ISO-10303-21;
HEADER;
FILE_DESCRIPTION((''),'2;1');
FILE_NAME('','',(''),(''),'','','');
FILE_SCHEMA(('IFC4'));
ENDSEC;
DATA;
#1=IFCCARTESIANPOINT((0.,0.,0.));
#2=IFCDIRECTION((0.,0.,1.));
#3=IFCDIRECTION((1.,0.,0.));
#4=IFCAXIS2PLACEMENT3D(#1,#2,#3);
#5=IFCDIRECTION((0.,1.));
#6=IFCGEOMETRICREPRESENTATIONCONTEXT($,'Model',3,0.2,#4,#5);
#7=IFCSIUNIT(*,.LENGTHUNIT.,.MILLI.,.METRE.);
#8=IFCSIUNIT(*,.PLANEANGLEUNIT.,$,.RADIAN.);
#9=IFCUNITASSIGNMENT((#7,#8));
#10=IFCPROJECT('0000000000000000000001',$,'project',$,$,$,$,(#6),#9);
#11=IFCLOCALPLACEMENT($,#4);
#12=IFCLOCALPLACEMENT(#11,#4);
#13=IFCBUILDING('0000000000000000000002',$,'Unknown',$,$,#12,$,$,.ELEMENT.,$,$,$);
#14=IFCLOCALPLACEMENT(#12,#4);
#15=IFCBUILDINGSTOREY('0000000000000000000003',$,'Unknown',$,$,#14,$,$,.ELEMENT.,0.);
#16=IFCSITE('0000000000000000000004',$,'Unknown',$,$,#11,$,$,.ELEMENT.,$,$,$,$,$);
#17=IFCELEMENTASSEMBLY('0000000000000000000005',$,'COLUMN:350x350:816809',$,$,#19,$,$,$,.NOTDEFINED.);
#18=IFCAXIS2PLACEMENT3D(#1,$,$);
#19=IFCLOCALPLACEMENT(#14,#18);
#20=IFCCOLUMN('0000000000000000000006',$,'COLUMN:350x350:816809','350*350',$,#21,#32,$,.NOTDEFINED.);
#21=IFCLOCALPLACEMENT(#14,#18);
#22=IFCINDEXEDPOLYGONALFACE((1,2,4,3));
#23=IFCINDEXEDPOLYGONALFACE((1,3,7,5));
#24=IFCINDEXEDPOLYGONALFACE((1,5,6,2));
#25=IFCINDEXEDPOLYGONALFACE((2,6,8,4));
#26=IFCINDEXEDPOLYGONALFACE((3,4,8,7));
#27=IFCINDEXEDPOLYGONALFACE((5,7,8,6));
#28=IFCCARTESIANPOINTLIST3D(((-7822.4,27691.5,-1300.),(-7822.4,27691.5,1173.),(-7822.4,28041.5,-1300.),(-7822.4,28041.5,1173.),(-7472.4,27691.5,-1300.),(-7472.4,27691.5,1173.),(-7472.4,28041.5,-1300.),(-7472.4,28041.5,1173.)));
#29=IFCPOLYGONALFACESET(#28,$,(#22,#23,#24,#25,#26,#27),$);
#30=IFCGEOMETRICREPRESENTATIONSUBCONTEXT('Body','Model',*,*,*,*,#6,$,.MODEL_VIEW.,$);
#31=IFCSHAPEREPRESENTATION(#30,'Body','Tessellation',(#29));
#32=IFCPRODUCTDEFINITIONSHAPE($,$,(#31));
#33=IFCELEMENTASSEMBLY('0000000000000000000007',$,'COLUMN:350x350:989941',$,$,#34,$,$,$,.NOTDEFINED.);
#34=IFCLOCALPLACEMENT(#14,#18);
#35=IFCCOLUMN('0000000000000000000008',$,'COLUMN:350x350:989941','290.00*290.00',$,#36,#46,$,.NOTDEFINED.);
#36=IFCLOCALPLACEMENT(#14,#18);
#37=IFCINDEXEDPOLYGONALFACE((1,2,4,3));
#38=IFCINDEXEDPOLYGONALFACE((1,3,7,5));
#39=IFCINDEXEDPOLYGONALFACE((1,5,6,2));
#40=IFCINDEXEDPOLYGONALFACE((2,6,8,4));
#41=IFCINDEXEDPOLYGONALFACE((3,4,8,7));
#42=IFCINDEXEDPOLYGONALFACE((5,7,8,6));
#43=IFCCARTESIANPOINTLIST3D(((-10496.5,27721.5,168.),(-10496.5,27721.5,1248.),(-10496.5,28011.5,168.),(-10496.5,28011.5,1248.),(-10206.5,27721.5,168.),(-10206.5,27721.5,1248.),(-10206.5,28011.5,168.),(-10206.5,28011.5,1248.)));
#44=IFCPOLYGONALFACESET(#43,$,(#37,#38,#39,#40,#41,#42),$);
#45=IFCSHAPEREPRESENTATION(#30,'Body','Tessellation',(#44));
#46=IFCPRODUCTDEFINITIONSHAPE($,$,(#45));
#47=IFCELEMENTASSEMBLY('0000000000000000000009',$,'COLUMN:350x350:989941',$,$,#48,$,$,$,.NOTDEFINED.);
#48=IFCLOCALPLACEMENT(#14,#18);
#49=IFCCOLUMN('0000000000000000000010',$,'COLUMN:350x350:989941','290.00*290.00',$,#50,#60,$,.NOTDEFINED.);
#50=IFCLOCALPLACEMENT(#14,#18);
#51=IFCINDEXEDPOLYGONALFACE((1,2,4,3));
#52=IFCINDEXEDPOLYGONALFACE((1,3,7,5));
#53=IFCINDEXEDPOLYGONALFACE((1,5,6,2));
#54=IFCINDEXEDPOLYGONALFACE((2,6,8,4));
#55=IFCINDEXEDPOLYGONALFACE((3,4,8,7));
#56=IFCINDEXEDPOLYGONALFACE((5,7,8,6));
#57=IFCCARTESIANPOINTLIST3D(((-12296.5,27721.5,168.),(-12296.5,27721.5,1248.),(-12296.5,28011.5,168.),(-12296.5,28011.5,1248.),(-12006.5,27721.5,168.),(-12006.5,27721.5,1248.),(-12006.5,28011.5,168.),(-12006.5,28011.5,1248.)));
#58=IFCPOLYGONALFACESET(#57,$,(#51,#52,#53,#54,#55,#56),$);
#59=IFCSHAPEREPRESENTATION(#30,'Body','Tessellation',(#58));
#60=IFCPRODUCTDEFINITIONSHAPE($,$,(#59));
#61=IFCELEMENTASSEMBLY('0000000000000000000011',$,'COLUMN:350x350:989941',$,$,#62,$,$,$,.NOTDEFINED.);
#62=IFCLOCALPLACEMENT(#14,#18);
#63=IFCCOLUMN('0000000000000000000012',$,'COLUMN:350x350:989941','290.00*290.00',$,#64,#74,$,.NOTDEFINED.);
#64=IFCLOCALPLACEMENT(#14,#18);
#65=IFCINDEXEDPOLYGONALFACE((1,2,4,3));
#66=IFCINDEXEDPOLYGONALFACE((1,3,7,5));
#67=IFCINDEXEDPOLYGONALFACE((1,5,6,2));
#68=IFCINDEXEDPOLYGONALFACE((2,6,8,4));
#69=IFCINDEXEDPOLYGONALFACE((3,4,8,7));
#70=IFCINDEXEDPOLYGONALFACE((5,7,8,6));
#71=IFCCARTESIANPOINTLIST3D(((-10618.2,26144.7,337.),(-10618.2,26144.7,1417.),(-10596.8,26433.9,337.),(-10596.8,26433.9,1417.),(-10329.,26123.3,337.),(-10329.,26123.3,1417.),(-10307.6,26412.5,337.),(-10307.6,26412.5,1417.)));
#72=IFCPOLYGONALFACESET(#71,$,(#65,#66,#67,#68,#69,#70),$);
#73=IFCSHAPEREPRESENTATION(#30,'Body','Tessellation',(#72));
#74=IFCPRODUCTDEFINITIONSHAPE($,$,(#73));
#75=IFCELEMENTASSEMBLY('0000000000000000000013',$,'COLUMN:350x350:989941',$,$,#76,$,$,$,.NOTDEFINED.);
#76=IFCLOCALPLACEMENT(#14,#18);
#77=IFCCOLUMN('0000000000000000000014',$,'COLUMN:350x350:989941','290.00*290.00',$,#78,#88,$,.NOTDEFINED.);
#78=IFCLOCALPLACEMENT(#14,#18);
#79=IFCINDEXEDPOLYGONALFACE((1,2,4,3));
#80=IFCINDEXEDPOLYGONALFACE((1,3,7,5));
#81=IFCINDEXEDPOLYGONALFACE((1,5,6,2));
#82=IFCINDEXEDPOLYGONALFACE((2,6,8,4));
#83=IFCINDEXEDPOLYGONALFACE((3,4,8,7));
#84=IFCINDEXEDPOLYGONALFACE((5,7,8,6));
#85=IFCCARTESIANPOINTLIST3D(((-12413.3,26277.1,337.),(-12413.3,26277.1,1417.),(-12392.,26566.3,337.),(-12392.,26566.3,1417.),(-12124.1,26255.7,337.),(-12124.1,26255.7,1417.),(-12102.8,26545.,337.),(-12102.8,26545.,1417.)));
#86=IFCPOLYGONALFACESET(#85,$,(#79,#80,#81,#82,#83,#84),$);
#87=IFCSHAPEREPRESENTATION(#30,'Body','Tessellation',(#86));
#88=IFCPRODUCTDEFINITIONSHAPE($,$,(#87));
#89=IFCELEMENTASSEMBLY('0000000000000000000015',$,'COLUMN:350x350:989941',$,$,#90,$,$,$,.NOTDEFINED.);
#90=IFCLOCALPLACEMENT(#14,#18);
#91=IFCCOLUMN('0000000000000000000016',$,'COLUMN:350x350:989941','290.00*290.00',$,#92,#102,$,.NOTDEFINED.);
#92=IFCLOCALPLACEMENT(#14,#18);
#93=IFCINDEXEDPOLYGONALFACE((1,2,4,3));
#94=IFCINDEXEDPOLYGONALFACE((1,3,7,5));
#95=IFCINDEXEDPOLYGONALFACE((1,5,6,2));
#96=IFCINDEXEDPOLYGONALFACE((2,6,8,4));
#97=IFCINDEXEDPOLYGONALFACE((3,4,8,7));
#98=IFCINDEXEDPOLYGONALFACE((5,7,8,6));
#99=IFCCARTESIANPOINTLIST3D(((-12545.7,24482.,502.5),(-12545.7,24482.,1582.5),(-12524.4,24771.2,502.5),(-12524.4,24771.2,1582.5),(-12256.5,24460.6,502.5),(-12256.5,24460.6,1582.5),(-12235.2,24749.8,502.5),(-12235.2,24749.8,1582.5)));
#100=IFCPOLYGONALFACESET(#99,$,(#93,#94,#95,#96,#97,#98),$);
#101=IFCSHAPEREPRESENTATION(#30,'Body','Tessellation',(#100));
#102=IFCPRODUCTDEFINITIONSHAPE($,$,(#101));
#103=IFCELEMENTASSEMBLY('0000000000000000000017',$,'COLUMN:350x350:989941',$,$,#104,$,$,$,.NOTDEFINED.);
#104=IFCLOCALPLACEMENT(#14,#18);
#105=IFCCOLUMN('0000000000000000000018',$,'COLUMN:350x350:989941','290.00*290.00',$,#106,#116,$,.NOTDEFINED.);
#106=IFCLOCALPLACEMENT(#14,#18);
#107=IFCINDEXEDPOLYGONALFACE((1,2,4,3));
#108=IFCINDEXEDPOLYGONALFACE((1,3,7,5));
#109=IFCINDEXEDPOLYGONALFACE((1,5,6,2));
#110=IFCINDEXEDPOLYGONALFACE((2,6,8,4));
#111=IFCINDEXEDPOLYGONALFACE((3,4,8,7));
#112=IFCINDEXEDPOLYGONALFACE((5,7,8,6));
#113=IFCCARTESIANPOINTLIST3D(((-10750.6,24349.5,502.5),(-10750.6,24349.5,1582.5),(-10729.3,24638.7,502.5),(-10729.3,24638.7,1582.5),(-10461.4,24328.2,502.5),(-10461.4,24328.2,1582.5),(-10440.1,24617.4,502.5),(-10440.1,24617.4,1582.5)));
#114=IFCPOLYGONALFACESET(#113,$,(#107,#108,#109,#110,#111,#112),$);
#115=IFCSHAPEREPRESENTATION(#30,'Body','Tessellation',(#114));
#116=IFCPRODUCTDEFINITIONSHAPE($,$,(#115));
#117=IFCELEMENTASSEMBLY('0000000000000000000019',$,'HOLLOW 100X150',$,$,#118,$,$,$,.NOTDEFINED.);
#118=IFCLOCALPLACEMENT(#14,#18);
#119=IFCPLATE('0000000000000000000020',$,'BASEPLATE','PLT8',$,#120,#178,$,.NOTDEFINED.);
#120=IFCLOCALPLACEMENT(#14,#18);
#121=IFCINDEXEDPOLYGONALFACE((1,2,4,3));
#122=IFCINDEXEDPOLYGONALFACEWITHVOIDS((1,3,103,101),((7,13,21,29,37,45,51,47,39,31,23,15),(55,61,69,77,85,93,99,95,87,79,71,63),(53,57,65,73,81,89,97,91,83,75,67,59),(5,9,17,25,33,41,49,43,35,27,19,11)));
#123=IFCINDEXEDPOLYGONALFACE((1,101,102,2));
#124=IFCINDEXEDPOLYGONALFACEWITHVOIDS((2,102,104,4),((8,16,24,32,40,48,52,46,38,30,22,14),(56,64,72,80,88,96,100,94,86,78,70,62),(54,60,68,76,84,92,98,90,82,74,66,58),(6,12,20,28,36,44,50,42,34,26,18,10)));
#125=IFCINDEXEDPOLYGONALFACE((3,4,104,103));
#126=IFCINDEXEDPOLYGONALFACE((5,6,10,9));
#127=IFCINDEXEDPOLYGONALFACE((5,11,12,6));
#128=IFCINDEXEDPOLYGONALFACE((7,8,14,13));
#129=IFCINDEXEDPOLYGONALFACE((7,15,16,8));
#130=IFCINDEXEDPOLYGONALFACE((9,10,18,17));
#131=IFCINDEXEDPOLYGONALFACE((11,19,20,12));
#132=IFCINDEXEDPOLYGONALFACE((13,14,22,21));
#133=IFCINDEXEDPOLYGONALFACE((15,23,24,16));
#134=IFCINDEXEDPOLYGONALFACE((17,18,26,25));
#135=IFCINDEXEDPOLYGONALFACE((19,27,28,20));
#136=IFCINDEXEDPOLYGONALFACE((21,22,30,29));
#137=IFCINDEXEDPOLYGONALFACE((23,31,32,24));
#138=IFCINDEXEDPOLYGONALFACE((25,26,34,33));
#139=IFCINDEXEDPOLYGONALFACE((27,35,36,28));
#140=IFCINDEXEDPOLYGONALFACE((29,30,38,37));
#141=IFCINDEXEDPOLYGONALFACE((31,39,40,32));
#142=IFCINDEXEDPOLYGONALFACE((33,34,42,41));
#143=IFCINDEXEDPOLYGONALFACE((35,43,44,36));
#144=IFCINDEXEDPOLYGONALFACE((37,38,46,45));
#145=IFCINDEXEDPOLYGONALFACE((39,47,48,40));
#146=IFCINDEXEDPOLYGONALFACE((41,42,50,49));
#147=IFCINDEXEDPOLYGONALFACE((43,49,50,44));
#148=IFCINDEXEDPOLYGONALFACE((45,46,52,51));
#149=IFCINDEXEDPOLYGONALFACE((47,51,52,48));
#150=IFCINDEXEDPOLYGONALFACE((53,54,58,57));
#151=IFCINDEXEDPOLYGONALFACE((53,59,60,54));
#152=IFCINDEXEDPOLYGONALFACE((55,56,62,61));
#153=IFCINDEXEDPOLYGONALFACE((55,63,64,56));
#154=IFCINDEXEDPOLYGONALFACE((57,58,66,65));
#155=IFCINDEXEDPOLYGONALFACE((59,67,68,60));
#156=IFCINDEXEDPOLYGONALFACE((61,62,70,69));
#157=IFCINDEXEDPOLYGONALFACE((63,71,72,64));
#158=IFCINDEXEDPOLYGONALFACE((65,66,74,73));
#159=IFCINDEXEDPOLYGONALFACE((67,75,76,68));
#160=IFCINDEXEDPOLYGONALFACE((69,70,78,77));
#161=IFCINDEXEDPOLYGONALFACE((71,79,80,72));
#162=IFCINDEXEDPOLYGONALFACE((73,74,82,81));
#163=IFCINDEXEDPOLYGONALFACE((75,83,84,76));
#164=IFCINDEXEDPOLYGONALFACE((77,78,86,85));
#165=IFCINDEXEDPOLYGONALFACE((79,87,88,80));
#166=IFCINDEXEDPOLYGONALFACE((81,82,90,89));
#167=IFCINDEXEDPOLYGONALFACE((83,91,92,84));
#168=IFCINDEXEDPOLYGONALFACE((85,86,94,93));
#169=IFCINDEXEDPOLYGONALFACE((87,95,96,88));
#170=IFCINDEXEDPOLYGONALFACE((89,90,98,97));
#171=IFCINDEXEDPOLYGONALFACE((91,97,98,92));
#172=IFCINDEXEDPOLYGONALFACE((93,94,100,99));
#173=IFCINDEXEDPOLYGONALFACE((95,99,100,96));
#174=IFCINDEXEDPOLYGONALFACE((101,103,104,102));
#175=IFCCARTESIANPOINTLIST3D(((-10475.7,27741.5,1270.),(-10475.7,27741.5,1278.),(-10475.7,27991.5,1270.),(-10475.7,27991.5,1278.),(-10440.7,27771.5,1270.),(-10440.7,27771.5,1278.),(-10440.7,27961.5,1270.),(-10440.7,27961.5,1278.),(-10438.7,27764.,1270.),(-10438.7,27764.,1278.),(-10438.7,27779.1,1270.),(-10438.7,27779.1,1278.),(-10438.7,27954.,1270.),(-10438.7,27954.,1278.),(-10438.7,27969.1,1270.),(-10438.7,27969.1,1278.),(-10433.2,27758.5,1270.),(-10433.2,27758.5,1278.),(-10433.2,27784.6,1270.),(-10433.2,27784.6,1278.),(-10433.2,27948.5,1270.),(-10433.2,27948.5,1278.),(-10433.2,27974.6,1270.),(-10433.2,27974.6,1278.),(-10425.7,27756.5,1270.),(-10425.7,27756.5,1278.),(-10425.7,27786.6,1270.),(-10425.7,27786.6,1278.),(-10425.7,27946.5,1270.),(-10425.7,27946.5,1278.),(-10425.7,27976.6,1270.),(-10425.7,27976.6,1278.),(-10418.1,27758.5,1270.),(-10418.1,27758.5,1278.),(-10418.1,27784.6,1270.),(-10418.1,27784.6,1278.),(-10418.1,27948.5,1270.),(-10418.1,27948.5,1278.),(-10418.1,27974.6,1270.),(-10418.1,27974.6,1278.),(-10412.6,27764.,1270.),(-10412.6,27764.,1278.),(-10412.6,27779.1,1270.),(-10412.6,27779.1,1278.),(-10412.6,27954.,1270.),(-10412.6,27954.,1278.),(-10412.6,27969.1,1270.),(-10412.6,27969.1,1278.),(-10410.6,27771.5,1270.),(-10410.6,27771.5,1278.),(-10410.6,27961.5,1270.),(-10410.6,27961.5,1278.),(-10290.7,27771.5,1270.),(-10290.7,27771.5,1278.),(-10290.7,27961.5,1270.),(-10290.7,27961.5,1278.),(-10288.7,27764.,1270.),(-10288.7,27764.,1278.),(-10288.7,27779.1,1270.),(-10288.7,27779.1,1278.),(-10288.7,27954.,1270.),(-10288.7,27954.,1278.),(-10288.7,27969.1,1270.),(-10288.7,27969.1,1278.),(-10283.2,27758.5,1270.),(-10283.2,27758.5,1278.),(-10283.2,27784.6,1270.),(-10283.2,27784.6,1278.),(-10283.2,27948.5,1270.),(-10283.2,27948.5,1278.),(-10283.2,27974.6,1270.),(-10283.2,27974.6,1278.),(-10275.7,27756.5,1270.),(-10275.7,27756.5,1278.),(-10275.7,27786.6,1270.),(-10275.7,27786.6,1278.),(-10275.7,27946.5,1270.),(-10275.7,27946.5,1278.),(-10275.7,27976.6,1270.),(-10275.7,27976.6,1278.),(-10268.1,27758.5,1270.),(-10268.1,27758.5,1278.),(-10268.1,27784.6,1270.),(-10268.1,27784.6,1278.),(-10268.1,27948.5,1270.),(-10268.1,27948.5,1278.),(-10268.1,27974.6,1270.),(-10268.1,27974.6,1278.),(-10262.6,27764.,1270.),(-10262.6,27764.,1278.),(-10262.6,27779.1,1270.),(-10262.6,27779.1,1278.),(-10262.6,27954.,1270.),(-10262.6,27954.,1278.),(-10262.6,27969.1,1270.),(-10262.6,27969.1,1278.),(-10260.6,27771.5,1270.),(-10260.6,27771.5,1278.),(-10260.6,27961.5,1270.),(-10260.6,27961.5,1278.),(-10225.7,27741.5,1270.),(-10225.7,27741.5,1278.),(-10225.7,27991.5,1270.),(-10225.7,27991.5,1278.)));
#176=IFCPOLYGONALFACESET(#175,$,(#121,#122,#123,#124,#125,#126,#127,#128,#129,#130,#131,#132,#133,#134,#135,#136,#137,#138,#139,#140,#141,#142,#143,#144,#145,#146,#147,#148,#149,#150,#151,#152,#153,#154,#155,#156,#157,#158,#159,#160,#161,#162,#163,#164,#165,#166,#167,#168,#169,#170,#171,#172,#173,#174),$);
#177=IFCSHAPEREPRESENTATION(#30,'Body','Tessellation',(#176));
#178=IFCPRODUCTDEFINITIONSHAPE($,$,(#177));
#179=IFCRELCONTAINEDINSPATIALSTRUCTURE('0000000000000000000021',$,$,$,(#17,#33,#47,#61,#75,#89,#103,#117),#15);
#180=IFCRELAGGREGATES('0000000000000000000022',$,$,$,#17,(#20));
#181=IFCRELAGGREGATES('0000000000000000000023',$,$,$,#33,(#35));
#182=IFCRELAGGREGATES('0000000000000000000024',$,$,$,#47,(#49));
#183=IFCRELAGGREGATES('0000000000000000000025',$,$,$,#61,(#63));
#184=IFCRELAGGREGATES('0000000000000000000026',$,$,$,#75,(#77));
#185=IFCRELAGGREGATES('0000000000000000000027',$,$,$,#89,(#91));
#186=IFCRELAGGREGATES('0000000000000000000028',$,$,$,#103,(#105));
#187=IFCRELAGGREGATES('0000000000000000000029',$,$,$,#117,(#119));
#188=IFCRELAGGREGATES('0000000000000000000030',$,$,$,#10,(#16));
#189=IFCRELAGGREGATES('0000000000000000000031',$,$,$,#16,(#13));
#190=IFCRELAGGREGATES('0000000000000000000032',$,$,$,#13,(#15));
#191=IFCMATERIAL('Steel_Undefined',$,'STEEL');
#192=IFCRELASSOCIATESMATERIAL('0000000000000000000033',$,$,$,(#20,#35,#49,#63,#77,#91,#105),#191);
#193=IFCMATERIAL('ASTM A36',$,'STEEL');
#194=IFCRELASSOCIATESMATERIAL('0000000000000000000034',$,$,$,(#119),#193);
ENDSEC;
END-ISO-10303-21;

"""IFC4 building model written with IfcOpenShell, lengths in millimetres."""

from ifc_helpers import new_model, si_unit, direction, frame, origin_with_axes, place, context, subcontext, project, spatial, line, indexed_curve, outline, extrude, material, element, aggregate, save


model = new_model("IFC4")

# Units and contexts
model_context = context("Model", 3, precision=0.2, world=origin_with_axes(), true_north=direction((0.0, 1.0)))
body_context = subcontext(model_context, "Body", "Model", "MODEL_VIEW")
ifc_project = project(units=[si_unit("LENGTHUNIT", "METRE", prefix="MILLI"), si_unit("PLANEANGLEUNIT", "RADIAN")], contexts=[model_context])

# Site, building, storey
site_placement = place(None, origin_with_axes())
site = spatial("IfcSite", under=ifc_project, at=site_placement, Name="Unknown", CompositionType="ELEMENT")
building_placement = place(site_placement, origin_with_axes())
building = spatial("IfcBuilding", under=site, at=building_placement, Name="Unknown", CompositionType="ELEMENT")
storey_placement = place(building_placement, origin_with_axes())
storey = spatial("IfcBuildingStorey", under=building, at=storey_placement, Name="Unknown", CompositionType="ELEMENT", Elevation=0.0)

# Element assemblies, columns
assembly_1_placement = place(storey_placement, frame((-7647.4, 27866.5, -1300.0), z_axis=(1.0, 0.0, 0.0), x_axis=(0.0, 0.0, 1.0)))
assembly_1 = element("IfcElementAssembly", 1, at=assembly_1_placement, inside=storey, Name="COLUMN:350x350:816809", PredefinedType="NOTDEFINED")
ifc_material_1 = material(Name="Steel_Undefined", Category="STEEL")
column_1_placement = place(assembly_1_placement, origin_with_axes())
column_1 = element("IfcColumn", 2, at=column_1_placement, material=ifc_material_1, Name="COLUMN:350x350:816809", Description="350*350", PredefinedType="NOTDEFINED", context=body_context, shape_type="SolidModel", body=[
    extrude(outline(indexed_curve([(-175.0, -175.0), (175.0, -175.0), (175.0, 175.0), (-175.0, 175.0)], segments=[line(1, 2, 3, 4, 1)])), frame((0.0, 0.0, 0.0), z_axis=(-1.0, 0.0, 0.0), x_axis=(0.0, 0.0, 1.0)), (0.0, 0.0, -1.0), 2473.0),
])
aggregate(assembly_1, [column_1])
assembly_2_placement = place(storey_placement, frame((-10351.5, 27866.5, 168.0), z_axis=(1.0, 0.0, 0.0), x_axis=(0.0, 0.0, 1.0)))
assembly_2 = element("IfcElementAssembly", 3, at=assembly_2_placement, inside=storey, Name="COLUMN:350x350:989941", PredefinedType="NOTDEFINED")
column_2_placement = place(assembly_2_placement, origin_with_axes())
column_2 = element("IfcColumn", 4, at=column_2_placement, material=ifc_material_1, Name="COLUMN:350x350:989941", Description="290.00*290.00", PredefinedType="NOTDEFINED", context=body_context, shape_type="SolidModel", body=[
    extrude(outline(indexed_curve([(-145.0, -145.0), (145.0, -145.0), (145.0, 145.0), (-145.0, 145.0)], segments=[line(1, 2, 3, 4, 1)])), frame((0.0, 0.0, 0.0), z_axis=(-1.0, 0.0, 0.0), x_axis=(0.0, 0.0, 1.0)), (0.0, 0.0, -1.0), 1080.0),
])
aggregate(assembly_2, [column_2])
assembly_3_placement = place(storey_placement, frame((-12151.5, 27866.5, 168.0), z_axis=(1.0, 0.0, 0.0), x_axis=(0.0, 0.0, 1.0)))
assembly_3 = element("IfcElementAssembly", 5, at=assembly_3_placement, inside=storey, Name="COLUMN:350x350:989941", PredefinedType="NOTDEFINED")
column_3_placement = place(assembly_3_placement, origin_with_axes())
column_3 = element("IfcColumn", 6, at=column_3_placement, material=ifc_material_1, Name="COLUMN:350x350:989941", Description="290.00*290.00", PredefinedType="NOTDEFINED", context=body_context, shape_type="SolidModel", body=[
    extrude(outline(indexed_curve([(-145.0, -145.0), (145.0, -145.0), (145.0, 145.0), (-145.0, 145.0)], segments=[line(1, 2, 3, 4, 1)])), frame((0.0, 0.0, 0.0), z_axis=(-1.0, 0.0, 0.0), x_axis=(0.0, 0.0, 1.0)), (0.0, 0.0, -1.0), 1080.0),
])
aggregate(assembly_3, [column_3])
assembly_4_placement = place(storey_placement, frame((-10462.9, 26278.6, 337.0), z_axis=(0.99729, -0.073569, 0.0), x_axis=(0.0, 0.0, 1.0)))
assembly_4 = element("IfcElementAssembly", 7, at=assembly_4_placement, inside=storey, Name="COLUMN:350x350:989941", PredefinedType="NOTDEFINED")
column_4_placement = place(assembly_4_placement, origin_with_axes())
column_4 = element("IfcColumn", 8, at=column_4_placement, material=ifc_material_1, Name="COLUMN:350x350:989941", Description="290.00*290.00", PredefinedType="NOTDEFINED", context=body_context, shape_type="SolidModel", body=[
    extrude(outline(indexed_curve([(-145.0, -145.0), (145.0, -145.0), (145.0, 145.0), (-145.0, 145.0)], segments=[line(1, 2, 3, 4, 1)])), frame((0.0, 0.0, 0.0), z_axis=(-1.0, 0.0, 0.0), x_axis=(0.0, 0.0, 1.0)), (0.0, 0.0, -1.0), 1080.0),
])
aggregate(assembly_4, [column_4])
assembly_5_placement = place(storey_placement, frame((-12258.0, 26411.0, 337.0), z_axis=(0.99729, -0.073569, 0.0), x_axis=(0.0, 0.0, 1.0)))
assembly_5 = element("IfcElementAssembly", 9, at=assembly_5_placement, inside=storey, Name="COLUMN:350x350:989941", PredefinedType="NOTDEFINED")
column_5_placement = place(assembly_5_placement, origin_with_axes())
column_5 = element("IfcColumn", 10, at=column_5_placement, material=ifc_material_1, Name="COLUMN:350x350:989941", Description="290.00*290.00", PredefinedType="NOTDEFINED", context=body_context, shape_type="SolidModel", body=[
    extrude(outline(indexed_curve([(-145.0, -145.0), (145.0, -145.0), (145.0, 145.0), (-145.0, 145.0)], segments=[line(1, 2, 3, 4, 1)])), frame((0.0, 0.0, 0.0), z_axis=(-1.0, 0.0, 0.0), x_axis=(0.0, 0.0, 1.0)), (0.0, 0.0, -1.0), 1080.0),
])
aggregate(assembly_5, [column_5])
assembly_6_placement = place(storey_placement, frame((-12390.5, 24615.9, 502.5), z_axis=(0.99729, -0.073569, 0.0), x_axis=(0.0, 0.0, 1.0)))
assembly_6 = element("IfcElementAssembly", 11, at=assembly_6_placement, inside=storey, Name="COLUMN:350x350:989941", PredefinedType="NOTDEFINED")
column_6_placement = place(assembly_6_placement, origin_with_axes())
column_6 = element("IfcColumn", 12, at=column_6_placement, material=ifc_material_1, Name="COLUMN:350x350:989941", Description="290.00*290.00", PredefinedType="NOTDEFINED", context=body_context, shape_type="SolidModel", body=[
    extrude(outline(indexed_curve([(-145.0, -145.0), (145.0, -145.0), (145.0, 145.0), (-145.0, 145.0)], segments=[line(1, 2, 3, 4, 1)])), frame((0.0, 0.0, 0.0), z_axis=(-1.0, 0.0, 0.0), x_axis=(0.0, 0.0, 1.0)), (0.0, 0.0, -1.0), 1080.0),
])
aggregate(assembly_6, [column_6])
assembly_7_placement = place(storey_placement, frame((-10595.3, 24483.5, 502.5), z_axis=(0.99729, -0.073569, 0.0), x_axis=(0.0, 0.0, 1.0)))
assembly_7 = element("IfcElementAssembly", 13, at=assembly_7_placement, inside=storey, Name="COLUMN:350x350:989941", PredefinedType="NOTDEFINED")
column_7_placement = place(assembly_7_placement, origin_with_axes())
column_7 = element("IfcColumn", 14, at=column_7_placement, material=ifc_material_1, Name="COLUMN:350x350:989941", Description="290.00*290.00", PredefinedType="NOTDEFINED", context=body_context, shape_type="SolidModel", body=[
    extrude(outline(indexed_curve([(-145.0, -145.0), (145.0, -145.0), (145.0, 145.0), (-145.0, 145.0)], segments=[line(1, 2, 3, 4, 1)])), frame((0.0, 0.0, 0.0), z_axis=(-1.0, 0.0, 0.0), x_axis=(0.0, 0.0, 1.0)), (0.0, 0.0, -1.0), 1080.0),
])
aggregate(assembly_7, [column_7])

# Element assembly, plate, voiding features
assembly_8_placement = place(storey_placement, frame((-10350.7, 27866.5, 1179.9), z_axis=(-0.073569, -0.99729, 0.0), x_axis=(0.0, 0.0, 1.0)))
assembly_8 = element("IfcElementAssembly", 15, at=assembly_8_placement, inside=storey, Name="HOLLOW 100X150", PredefinedType="NOTDEFINED")
ifc_material_2 = material(Name="ASTM A36", Category="STEEL")
plate_1_placement = place(assembly_8_placement, frame((94.1, 133.9, -115.5), z_axis=(-1.0, 0.0, 0.0), x_axis=(0.0, -0.99729, -0.073569)))
plate_1 = element("IfcPlate", 16, at=plate_1_placement, material=ifc_material_2, Name="BASEPLATE", Description="PLT8", PredefinedType="NOTDEFINED", context=body_context, shape_type="SolidModel", body=[
    extrude(outline(indexed_curve([(0.0, 0.0), (250.0, 0.0), (250.0, 250.0), (0.0, 250.0)], segments=[line(1, 2, 3, 4, 1)])), frame((0.0, 0.0, 4.0), z_axis=(0.0, 0.0, 1.0), x_axis=(1.0, 0.0, 0.0)), (0.0, 0.0, -1.0), 8.0),
])
voiding_feature_1_placement = place(plate_1_placement, frame((200.0, 30.0, 4.5), z_axis=(-1.0, 0.0, 0.0), x_axis=(0.0, 0.0, -1.0)))
element("IfcVoidingFeature", 17, at=voiding_feature_1_placement, cuts=plate_1, Name="BEAM", PredefinedType="HOLE", context=body_context, shape_type="SolidModel", body=[
    extrude(outline(indexed_curve([(15.1, 0.0), (13.1, 7.5), (7.5, 13.1), (0.0, 15.1), (-7.5, 13.1), (-13.1, 7.5), (-15.1, 0.0), (-13.1, -7.5), (-7.5, -13.1), (0.0, -15.1), (7.5, -13.1), (13.1, -7.5)], segments=[line(1, 2, 3, 4, 5, 6, 7, 8, 9, 10, 11, 12, 1)])), frame((0.0, 0.0, 0.0), z_axis=(-1.0, 0.0, 0.0), x_axis=(0.0, 0.0, 1.0)), (0.0, 0.0, -1.0), 9.0),
])
voiding_feature_2_placement = place(plate_1_placement, frame((50.0, 30.0, 4.5), z_axis=(-1.0, 0.0, 0.0), x_axis=(0.0, 0.0, -1.0)))
element("IfcVoidingFeature", 18, at=voiding_feature_2_placement, cuts=plate_1, Name="BEAM", PredefinedType="HOLE", context=body_context, shape_type="SolidModel", body=[
    extrude(outline(indexed_curve([(15.1, 0.0), (13.1, 7.5), (7.5, 13.1), (0.0, 15.1), (-7.5, 13.1), (-13.1, 7.5), (-15.1, 0.0), (-13.1, -7.5), (-7.5, -13.1), (0.0, -15.1), (7.5, -13.1), (13.1, -7.5)], segments=[line(1, 2, 3, 4, 5, 6, 7, 8, 9, 10, 11, 12, 1)])), frame((0.0, 0.0, 0.0), z_axis=(-1.0, 0.0, 0.0), x_axis=(0.0, 0.0, 1.0)), (0.0, 0.0, -1.0), 9.0),
])
voiding_feature_3_placement = place(plate_1_placement, frame((200.0, 220.0, 4.5), z_axis=(-1.0, 0.0, 0.0), x_axis=(0.0, 0.0, -1.0)))
element("IfcVoidingFeature", 19, at=voiding_feature_3_placement, cuts=plate_1, Name="BEAM", PredefinedType="HOLE", context=body_context, shape_type="SolidModel", body=[
    extrude(outline(indexed_curve([(15.1, 0.0), (13.1, 7.5), (7.5, 13.1), (0.0, 15.1), (-7.5, 13.1), (-13.1, 7.5), (-15.1, 0.0), (-13.1, -7.5), (-7.5, -13.1), (0.0, -15.1), (7.5, -13.1), (13.1, -7.5)], segments=[line(1, 2, 3, 4, 5, 6, 7, 8, 9, 10, 11, 12, 1)])), frame((0.0, 0.0, 0.0), z_axis=(-1.0, 0.0, 0.0), x_axis=(0.0, 0.0, 1.0)), (0.0, 0.0, -1.0), 9.0),
])
voiding_feature_4_placement = place(plate_1_placement, frame((50.0, 220.0, 4.5), z_axis=(-1.0, 0.0, 0.0), x_axis=(0.0, 0.0, -1.0)))
element("IfcVoidingFeature", 20, at=voiding_feature_4_placement, cuts=plate_1, Name="BEAM", PredefinedType="HOLE", context=body_context, shape_type="SolidModel", body=[
    extrude(outline(indexed_curve([(15.1, 0.0), (13.1, 7.5), (7.5, 13.1), (0.0, 15.1), (-7.5, 13.1), (-13.1, 7.5), (-15.1, 0.0), (-13.1, -7.5), (-7.5, -13.1), (0.0, -15.1), (7.5, -13.1), (13.1, -7.5)], segments=[line(1, 2, 3, 4, 5, 6, 7, 8, 9, 10, 11, 12, 1)])), frame((0.0, 0.0, 0.0), z_axis=(-1.0, 0.0, 0.0), x_axis=(0.0, 0.0, 1.0)), (0.0, 0.0, -1.0), 9.0),
])
aggregate(assembly_8, [plate_1])

save(model, "model.ifc")
